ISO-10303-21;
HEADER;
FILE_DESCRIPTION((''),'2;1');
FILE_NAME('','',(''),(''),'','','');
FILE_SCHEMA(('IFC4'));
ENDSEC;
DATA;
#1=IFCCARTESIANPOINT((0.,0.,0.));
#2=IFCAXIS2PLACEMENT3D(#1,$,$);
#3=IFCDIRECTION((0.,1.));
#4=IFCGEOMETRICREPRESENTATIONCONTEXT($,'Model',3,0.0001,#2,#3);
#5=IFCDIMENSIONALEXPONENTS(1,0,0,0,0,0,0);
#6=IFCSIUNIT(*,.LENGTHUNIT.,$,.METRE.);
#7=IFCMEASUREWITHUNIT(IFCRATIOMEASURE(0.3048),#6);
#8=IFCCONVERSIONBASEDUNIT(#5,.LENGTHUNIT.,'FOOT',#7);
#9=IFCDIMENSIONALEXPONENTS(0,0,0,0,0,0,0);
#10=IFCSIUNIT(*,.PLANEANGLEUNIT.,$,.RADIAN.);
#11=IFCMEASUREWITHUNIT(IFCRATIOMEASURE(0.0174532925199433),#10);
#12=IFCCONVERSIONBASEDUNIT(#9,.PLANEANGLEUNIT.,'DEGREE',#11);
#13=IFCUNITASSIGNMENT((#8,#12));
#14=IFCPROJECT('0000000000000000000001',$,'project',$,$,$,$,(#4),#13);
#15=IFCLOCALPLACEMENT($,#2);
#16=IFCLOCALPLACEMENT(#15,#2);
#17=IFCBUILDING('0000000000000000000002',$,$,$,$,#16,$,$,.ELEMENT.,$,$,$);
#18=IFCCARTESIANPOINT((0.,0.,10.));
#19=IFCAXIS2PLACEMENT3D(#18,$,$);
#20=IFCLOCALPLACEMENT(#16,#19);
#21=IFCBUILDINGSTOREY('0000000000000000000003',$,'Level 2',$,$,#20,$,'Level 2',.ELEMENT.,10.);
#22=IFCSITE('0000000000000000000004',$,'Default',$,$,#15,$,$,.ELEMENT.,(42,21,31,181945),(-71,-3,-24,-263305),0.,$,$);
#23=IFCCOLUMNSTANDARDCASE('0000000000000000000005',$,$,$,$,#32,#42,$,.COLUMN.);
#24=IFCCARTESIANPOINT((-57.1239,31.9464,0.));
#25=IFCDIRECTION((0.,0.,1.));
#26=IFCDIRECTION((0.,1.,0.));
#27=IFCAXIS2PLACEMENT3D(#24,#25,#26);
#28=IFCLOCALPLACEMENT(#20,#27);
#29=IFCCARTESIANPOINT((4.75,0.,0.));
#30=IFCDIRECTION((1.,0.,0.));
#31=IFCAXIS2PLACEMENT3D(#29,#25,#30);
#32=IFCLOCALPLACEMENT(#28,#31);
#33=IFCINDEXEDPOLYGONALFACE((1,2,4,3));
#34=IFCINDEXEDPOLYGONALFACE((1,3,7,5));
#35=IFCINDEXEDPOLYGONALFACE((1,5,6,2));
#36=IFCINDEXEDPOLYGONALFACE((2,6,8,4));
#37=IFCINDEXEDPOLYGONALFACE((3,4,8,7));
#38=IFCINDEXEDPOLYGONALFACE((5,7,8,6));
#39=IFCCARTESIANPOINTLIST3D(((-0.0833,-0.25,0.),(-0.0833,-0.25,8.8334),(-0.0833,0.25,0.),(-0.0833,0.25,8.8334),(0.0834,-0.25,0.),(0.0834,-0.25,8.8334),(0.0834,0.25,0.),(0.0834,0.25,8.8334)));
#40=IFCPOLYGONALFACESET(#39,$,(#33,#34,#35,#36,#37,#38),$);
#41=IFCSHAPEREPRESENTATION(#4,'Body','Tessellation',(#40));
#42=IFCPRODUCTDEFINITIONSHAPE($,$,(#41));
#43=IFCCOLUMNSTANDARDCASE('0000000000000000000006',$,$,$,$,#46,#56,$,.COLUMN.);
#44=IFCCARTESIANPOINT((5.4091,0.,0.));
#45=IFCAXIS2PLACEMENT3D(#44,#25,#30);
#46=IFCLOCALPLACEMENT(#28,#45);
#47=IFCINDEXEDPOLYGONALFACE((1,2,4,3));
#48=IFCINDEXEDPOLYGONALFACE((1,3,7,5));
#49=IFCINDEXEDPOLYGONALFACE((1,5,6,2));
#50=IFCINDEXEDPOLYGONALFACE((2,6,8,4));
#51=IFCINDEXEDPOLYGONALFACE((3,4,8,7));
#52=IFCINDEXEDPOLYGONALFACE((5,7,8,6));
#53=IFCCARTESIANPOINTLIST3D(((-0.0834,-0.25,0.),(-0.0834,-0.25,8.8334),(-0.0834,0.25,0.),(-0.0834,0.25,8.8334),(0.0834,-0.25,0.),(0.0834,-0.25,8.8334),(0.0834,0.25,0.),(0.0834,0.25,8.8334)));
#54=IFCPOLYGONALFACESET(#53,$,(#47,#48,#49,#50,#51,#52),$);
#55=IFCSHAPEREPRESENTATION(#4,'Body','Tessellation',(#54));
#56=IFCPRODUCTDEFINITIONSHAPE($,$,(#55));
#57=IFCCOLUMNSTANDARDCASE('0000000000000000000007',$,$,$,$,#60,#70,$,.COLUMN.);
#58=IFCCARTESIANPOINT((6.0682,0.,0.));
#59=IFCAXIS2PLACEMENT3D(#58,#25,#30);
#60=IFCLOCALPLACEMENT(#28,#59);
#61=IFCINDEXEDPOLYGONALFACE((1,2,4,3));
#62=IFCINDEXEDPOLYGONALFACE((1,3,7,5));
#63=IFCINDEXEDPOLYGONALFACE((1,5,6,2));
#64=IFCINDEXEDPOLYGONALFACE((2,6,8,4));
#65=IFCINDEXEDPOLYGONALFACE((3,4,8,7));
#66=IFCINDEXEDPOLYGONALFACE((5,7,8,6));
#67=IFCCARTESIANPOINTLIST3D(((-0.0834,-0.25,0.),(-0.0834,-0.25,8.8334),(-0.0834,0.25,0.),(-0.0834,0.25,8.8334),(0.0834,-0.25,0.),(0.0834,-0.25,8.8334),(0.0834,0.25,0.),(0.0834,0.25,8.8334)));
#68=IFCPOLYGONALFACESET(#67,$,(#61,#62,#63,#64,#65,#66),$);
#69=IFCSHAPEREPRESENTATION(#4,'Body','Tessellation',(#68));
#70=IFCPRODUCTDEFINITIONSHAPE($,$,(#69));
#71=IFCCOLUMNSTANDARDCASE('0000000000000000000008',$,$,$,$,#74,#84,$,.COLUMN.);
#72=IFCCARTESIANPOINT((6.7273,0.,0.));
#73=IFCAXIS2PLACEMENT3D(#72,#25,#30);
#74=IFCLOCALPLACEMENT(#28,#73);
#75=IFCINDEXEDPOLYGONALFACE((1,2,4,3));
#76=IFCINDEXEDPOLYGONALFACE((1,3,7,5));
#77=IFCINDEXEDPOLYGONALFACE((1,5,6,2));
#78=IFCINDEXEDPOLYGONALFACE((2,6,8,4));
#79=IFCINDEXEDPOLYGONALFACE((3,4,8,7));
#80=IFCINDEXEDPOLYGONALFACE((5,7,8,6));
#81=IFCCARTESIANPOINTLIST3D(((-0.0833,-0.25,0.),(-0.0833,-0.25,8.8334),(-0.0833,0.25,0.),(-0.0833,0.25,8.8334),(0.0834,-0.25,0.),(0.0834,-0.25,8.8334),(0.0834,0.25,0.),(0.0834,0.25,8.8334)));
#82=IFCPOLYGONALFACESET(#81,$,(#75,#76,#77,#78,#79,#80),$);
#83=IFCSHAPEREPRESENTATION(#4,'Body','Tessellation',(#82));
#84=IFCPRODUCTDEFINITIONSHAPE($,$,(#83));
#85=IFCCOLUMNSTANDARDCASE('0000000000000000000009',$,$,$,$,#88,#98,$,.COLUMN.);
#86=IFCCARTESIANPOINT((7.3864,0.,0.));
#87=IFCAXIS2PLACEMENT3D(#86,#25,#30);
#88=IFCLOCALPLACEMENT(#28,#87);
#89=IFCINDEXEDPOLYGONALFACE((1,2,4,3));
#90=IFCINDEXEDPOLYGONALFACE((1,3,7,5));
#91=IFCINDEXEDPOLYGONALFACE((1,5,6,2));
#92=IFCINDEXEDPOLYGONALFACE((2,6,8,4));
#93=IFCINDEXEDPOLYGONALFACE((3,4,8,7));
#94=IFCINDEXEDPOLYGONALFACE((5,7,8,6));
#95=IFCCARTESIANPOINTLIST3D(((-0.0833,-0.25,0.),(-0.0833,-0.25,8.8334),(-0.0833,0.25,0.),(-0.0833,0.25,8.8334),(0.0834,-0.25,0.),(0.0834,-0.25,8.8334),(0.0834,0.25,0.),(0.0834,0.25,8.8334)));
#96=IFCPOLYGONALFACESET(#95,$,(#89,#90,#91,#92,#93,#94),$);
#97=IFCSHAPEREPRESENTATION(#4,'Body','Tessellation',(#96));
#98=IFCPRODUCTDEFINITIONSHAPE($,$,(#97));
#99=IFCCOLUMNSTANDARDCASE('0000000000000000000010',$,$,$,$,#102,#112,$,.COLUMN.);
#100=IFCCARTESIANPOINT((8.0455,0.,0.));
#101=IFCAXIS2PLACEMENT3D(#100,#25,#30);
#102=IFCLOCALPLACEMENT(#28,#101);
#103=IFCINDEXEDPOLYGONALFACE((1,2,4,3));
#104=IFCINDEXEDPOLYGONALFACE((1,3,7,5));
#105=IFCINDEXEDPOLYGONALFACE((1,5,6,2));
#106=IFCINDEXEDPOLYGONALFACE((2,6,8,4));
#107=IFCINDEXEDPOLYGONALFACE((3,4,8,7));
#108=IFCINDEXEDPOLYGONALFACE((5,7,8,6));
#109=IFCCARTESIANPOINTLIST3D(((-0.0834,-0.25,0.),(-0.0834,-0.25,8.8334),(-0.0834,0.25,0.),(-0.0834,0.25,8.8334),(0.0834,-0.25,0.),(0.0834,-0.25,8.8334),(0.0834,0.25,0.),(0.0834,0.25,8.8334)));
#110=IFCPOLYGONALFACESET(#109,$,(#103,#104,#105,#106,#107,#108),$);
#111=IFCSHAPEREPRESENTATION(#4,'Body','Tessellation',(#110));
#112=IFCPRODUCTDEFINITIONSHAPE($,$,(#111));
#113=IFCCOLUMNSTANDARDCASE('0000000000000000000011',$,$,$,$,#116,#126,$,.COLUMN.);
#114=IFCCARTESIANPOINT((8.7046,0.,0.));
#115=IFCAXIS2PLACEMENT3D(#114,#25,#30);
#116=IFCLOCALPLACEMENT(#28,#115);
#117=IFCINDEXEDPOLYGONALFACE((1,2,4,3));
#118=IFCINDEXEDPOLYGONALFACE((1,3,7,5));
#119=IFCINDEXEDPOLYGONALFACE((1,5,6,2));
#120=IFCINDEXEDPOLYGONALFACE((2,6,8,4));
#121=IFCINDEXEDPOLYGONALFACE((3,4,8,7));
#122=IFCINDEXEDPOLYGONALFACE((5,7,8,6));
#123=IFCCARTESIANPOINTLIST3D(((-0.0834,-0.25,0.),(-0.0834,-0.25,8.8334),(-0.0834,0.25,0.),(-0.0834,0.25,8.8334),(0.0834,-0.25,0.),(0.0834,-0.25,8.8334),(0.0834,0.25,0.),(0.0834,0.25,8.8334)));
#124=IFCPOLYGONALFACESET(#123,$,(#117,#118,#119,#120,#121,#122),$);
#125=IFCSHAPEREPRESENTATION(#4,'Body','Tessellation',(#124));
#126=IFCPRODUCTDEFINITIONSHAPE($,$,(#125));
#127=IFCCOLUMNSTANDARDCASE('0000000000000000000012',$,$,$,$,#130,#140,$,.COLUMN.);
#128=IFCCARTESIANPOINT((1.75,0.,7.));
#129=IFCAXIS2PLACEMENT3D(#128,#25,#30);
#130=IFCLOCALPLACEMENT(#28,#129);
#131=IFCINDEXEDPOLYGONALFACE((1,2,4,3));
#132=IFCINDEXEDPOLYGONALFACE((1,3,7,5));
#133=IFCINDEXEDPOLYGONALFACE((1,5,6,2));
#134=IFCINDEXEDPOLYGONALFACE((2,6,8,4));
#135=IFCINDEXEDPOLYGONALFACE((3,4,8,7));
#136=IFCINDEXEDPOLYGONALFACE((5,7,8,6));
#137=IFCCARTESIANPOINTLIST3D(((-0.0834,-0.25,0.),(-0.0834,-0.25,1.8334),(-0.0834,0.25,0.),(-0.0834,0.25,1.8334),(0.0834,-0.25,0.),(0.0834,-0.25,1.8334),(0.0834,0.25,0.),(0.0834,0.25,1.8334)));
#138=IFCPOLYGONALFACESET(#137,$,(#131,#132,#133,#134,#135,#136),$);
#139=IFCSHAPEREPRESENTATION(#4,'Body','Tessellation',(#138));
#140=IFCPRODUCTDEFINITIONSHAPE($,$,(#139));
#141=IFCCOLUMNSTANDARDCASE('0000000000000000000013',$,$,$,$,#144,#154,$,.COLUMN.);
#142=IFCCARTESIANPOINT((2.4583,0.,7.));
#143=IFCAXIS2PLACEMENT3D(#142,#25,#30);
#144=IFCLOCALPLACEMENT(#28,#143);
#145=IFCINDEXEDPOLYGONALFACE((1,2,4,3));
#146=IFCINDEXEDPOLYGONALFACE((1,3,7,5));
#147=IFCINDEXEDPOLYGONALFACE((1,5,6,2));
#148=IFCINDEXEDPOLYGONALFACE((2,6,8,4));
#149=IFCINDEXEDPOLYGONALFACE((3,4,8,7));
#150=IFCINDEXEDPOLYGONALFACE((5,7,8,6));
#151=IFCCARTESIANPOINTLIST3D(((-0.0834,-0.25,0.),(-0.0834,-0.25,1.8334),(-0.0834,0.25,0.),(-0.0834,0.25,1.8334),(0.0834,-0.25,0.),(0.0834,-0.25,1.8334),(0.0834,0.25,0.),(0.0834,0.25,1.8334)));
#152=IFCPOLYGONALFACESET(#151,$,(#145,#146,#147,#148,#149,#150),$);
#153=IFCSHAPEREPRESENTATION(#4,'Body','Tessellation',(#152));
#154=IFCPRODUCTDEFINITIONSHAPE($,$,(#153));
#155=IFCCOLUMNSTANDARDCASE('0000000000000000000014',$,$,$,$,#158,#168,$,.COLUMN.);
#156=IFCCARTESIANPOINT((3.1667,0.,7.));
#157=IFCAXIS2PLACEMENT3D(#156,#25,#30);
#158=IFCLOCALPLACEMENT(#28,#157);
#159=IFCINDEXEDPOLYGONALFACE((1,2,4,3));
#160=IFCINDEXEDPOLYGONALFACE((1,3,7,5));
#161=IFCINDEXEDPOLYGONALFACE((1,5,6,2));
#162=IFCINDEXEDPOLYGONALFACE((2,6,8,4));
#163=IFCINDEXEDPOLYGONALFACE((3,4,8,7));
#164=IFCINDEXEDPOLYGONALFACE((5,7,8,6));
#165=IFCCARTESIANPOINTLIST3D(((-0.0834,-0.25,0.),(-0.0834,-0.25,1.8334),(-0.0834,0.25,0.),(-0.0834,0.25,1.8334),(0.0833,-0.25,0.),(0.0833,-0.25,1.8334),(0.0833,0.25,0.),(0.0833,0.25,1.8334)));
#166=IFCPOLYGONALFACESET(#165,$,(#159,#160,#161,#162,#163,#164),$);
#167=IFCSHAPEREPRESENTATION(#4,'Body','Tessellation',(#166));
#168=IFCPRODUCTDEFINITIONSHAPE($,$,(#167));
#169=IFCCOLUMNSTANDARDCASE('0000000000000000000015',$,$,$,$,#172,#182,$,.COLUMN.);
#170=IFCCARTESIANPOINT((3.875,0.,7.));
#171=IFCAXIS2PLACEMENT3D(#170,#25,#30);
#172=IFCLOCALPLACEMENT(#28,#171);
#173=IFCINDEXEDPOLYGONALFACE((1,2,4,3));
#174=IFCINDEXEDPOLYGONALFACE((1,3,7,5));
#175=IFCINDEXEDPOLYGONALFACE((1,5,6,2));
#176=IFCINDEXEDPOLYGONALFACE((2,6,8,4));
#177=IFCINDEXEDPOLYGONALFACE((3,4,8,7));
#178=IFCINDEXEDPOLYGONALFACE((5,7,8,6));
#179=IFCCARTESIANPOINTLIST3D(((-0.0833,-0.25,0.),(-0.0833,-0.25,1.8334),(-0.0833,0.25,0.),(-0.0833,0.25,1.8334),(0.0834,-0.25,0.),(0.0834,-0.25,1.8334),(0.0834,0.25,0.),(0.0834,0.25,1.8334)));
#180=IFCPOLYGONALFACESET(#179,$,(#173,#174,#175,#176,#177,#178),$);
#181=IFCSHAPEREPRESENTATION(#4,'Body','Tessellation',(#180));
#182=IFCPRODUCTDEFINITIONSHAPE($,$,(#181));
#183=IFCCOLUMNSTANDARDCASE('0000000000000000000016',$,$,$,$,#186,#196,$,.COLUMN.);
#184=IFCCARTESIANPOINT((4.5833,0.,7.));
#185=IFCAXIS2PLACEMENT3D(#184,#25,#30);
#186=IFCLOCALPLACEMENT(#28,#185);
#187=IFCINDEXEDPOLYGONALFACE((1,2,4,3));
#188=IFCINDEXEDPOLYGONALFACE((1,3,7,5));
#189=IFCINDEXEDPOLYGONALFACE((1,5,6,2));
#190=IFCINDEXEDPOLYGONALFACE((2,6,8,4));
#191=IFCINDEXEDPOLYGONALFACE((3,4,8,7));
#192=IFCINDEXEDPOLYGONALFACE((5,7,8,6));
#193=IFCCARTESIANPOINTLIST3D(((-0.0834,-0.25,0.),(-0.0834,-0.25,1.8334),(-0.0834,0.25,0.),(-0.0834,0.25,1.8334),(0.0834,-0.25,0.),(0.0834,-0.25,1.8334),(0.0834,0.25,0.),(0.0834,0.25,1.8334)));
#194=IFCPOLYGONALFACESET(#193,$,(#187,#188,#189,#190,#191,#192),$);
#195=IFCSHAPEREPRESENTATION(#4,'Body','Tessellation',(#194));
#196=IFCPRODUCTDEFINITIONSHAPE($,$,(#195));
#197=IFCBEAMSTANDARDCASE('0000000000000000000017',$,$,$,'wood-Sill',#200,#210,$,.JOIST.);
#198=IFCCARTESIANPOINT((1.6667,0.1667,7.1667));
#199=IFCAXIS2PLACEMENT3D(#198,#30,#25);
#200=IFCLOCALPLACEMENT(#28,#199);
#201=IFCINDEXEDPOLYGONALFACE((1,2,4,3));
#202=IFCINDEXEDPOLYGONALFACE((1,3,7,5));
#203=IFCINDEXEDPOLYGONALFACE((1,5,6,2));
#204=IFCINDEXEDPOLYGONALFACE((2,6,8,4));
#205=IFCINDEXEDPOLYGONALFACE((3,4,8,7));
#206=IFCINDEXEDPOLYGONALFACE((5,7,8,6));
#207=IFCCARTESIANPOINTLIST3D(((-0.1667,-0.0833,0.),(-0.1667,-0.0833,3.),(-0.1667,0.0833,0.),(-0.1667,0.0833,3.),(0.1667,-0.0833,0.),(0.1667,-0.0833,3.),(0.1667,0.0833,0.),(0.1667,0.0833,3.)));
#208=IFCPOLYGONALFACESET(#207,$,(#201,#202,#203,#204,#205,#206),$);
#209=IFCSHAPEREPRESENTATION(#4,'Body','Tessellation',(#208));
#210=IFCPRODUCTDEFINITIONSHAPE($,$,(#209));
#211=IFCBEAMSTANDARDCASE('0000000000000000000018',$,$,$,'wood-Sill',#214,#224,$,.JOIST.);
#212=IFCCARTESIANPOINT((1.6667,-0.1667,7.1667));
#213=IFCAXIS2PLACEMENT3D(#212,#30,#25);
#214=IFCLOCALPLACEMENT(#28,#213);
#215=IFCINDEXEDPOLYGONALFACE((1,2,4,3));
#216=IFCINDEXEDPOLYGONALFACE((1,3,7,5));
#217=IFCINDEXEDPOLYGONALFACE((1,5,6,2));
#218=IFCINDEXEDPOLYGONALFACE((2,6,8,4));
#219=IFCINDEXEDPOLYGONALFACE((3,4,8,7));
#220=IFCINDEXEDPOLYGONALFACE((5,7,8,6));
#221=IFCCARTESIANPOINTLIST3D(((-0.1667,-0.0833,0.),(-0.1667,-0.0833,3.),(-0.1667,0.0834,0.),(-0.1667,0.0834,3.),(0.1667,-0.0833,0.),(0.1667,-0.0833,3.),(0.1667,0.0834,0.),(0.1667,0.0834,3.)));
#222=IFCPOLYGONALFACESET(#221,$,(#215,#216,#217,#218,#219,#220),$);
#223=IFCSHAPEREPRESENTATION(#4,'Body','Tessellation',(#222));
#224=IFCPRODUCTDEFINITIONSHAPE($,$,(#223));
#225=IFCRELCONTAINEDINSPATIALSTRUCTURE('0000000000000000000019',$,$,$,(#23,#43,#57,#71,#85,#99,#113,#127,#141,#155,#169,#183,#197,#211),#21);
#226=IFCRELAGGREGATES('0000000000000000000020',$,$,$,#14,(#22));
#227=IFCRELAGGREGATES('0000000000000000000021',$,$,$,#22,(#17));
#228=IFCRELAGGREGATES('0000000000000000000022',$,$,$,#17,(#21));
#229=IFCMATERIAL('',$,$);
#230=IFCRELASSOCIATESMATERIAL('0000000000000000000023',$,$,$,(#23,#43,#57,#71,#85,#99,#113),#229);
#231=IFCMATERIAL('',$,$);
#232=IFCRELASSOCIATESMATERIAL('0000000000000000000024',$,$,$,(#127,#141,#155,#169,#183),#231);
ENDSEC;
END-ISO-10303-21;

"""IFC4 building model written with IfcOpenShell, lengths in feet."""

from ifc_helpers import new_model, entity, si_unit, converted_unit, direction, frame, origin, origin_with_axes, place, context, project, spatial, rectangle, extrude, material, element, save


model = new_model("IFC4")

# Units and contexts
model_context = context("Model", 3, precision=0.0001, world=origin(), true_north=direction((0.0, 1.0)))
ifc_project = project(units=[converted_unit("LENGTHUNIT", "FOOT", entity("IfcRatioMeasure", 0.3048), si_unit("LENGTHUNIT", "METRE"), dimensions=[1, 0, 0, 0, 0, 0, 0]), converted_unit("PLANEANGLEUNIT", "DEGREE", entity("IfcRatioMeasure", 0.0174532925199433), si_unit("PLANEANGLEUNIT", "RADIAN"), dimensions=[0, 0, 0, 0, 0, 0, 0])], contexts=[model_context])

# Site, building, storey
site_placement = place(None, origin())
site = spatial("IfcSite", under=ifc_project, at=site_placement, Name="Default", CompositionType="ELEMENT", RefLatitude=(42, 21, 31, 181945), RefLongitude=(-71, -3, -24, -263305), RefElevation=0.0)
building_placement = place(site_placement, origin())
building = spatial("IfcBuilding", under=site, at=building_placement, CompositionType="ELEMENT")
storey_placement = place(building_placement, frame((0.0, 0.0, 10.0)))
storey = spatial("IfcBuildingStorey", under=building, at=storey_placement, Name="Level 2", LongName="Level 2", CompositionType="ELEMENT", Elevation=10.0)

# Columns
placement_1 = place(storey_placement, frame((-57.1239, 31.9464, 0.0), z_axis=(0.0, 0.0, 1.0), x_axis=(0.0, 1.0, 0.0)))
ifc_material_1 = material(Name="")
for number, where, z_axis, x_axis in (
    (1, (4.75, 0.0, 0.0), (0.0, 0.0, 1.0), (1.0, 0.0, 0.0)),
    (2, (5.4091, 0.0, 0.0), (0.0, 0.0, 1.0), (1.0, 0.0, 0.0)),
    (3, (6.0682, 0.0, 0.0), (0.0, 0.0, 1.0), (1.0, 0.0, 0.0)),
    (4, (6.7273, 0.0, 0.0), (0.0, 0.0, 1.0), (1.0, 0.0, 0.0)),
    (5, (7.3864, 0.0, 0.0), (0.0, 0.0, 1.0), (1.0, 0.0, 0.0)),
    (6, (8.0455, 0.0, 0.0), (0.0, 0.0, 1.0), (1.0, 0.0, 0.0)),
    (7, (8.7046, 0.0, 0.0), (0.0, 0.0, 1.0), (1.0, 0.0, 0.0)),
):
    element("IfcColumnStandardCase", number, at=place(placement_1, frame(where, z_axis=z_axis, x_axis=x_axis)), inside=storey, material=ifc_material_1, PredefinedType="COLUMN", context=model_context, shape_type="SweptSolid", body=[
        extrude(rectangle(XDim=0.1667, YDim=0.5), origin(), (0.0, 0.0, 1.0), 8.8334),
    ])
ifc_material_2 = material(Name="")
for number, where, z_axis, x_axis in (
    (8, (1.75, 0.0, 7.0), (0.0, 0.0, 1.0), (1.0, 0.0, 0.0)),
    (9, (2.4583, 0.0, 7.0), (0.0, 0.0, 1.0), (1.0, 0.0, 0.0)),
    (10, (3.1667, 0.0, 7.0), (0.0, 0.0, 1.0), (1.0, 0.0, 0.0)),
    (11, (3.875, 0.0, 7.0), (0.0, 0.0, 1.0), (1.0, 0.0, 0.0)),
    (12, (4.5833, 0.0, 7.0), (0.0, 0.0, 1.0), (1.0, 0.0, 0.0)),
):
    element("IfcColumnStandardCase", number, at=place(placement_1, frame(where, z_axis=z_axis, x_axis=x_axis)), inside=storey, material=ifc_material_2, PredefinedType="COLUMN", context=model_context, shape_type="SweptSolid", body=[
        extrude(rectangle(XDim=0.1667, YDim=0.5), origin(), (0.0, 0.0, 1.0), 1.8334),
    ])

# Beams
for number, where, z_axis, x_axis in (
    (13, (1.6667, 0.1667, 7.1667), (1.0, 0.0, 0.0), (0.0, 0.0, 1.0)),
    (14, (1.6667, -0.1667, 7.1667), (1.0, 0.0, 0.0), (0.0, 0.0, 1.0)),
):
    element("IfcBeamStandardCase", number, at=place(placement_1, frame(where, z_axis=z_axis, x_axis=x_axis)), inside=storey, ObjectType="wood-Sill", PredefinedType="JOIST", context=model_context, shape_type="SweptSolid", body=[
        extrude(rectangle(XDim=0.3333, YDim=0.1667), origin_with_axes(), (0.0, 0.0, 1.0), 3.0),
    ])

save(model, "model.ifc")
